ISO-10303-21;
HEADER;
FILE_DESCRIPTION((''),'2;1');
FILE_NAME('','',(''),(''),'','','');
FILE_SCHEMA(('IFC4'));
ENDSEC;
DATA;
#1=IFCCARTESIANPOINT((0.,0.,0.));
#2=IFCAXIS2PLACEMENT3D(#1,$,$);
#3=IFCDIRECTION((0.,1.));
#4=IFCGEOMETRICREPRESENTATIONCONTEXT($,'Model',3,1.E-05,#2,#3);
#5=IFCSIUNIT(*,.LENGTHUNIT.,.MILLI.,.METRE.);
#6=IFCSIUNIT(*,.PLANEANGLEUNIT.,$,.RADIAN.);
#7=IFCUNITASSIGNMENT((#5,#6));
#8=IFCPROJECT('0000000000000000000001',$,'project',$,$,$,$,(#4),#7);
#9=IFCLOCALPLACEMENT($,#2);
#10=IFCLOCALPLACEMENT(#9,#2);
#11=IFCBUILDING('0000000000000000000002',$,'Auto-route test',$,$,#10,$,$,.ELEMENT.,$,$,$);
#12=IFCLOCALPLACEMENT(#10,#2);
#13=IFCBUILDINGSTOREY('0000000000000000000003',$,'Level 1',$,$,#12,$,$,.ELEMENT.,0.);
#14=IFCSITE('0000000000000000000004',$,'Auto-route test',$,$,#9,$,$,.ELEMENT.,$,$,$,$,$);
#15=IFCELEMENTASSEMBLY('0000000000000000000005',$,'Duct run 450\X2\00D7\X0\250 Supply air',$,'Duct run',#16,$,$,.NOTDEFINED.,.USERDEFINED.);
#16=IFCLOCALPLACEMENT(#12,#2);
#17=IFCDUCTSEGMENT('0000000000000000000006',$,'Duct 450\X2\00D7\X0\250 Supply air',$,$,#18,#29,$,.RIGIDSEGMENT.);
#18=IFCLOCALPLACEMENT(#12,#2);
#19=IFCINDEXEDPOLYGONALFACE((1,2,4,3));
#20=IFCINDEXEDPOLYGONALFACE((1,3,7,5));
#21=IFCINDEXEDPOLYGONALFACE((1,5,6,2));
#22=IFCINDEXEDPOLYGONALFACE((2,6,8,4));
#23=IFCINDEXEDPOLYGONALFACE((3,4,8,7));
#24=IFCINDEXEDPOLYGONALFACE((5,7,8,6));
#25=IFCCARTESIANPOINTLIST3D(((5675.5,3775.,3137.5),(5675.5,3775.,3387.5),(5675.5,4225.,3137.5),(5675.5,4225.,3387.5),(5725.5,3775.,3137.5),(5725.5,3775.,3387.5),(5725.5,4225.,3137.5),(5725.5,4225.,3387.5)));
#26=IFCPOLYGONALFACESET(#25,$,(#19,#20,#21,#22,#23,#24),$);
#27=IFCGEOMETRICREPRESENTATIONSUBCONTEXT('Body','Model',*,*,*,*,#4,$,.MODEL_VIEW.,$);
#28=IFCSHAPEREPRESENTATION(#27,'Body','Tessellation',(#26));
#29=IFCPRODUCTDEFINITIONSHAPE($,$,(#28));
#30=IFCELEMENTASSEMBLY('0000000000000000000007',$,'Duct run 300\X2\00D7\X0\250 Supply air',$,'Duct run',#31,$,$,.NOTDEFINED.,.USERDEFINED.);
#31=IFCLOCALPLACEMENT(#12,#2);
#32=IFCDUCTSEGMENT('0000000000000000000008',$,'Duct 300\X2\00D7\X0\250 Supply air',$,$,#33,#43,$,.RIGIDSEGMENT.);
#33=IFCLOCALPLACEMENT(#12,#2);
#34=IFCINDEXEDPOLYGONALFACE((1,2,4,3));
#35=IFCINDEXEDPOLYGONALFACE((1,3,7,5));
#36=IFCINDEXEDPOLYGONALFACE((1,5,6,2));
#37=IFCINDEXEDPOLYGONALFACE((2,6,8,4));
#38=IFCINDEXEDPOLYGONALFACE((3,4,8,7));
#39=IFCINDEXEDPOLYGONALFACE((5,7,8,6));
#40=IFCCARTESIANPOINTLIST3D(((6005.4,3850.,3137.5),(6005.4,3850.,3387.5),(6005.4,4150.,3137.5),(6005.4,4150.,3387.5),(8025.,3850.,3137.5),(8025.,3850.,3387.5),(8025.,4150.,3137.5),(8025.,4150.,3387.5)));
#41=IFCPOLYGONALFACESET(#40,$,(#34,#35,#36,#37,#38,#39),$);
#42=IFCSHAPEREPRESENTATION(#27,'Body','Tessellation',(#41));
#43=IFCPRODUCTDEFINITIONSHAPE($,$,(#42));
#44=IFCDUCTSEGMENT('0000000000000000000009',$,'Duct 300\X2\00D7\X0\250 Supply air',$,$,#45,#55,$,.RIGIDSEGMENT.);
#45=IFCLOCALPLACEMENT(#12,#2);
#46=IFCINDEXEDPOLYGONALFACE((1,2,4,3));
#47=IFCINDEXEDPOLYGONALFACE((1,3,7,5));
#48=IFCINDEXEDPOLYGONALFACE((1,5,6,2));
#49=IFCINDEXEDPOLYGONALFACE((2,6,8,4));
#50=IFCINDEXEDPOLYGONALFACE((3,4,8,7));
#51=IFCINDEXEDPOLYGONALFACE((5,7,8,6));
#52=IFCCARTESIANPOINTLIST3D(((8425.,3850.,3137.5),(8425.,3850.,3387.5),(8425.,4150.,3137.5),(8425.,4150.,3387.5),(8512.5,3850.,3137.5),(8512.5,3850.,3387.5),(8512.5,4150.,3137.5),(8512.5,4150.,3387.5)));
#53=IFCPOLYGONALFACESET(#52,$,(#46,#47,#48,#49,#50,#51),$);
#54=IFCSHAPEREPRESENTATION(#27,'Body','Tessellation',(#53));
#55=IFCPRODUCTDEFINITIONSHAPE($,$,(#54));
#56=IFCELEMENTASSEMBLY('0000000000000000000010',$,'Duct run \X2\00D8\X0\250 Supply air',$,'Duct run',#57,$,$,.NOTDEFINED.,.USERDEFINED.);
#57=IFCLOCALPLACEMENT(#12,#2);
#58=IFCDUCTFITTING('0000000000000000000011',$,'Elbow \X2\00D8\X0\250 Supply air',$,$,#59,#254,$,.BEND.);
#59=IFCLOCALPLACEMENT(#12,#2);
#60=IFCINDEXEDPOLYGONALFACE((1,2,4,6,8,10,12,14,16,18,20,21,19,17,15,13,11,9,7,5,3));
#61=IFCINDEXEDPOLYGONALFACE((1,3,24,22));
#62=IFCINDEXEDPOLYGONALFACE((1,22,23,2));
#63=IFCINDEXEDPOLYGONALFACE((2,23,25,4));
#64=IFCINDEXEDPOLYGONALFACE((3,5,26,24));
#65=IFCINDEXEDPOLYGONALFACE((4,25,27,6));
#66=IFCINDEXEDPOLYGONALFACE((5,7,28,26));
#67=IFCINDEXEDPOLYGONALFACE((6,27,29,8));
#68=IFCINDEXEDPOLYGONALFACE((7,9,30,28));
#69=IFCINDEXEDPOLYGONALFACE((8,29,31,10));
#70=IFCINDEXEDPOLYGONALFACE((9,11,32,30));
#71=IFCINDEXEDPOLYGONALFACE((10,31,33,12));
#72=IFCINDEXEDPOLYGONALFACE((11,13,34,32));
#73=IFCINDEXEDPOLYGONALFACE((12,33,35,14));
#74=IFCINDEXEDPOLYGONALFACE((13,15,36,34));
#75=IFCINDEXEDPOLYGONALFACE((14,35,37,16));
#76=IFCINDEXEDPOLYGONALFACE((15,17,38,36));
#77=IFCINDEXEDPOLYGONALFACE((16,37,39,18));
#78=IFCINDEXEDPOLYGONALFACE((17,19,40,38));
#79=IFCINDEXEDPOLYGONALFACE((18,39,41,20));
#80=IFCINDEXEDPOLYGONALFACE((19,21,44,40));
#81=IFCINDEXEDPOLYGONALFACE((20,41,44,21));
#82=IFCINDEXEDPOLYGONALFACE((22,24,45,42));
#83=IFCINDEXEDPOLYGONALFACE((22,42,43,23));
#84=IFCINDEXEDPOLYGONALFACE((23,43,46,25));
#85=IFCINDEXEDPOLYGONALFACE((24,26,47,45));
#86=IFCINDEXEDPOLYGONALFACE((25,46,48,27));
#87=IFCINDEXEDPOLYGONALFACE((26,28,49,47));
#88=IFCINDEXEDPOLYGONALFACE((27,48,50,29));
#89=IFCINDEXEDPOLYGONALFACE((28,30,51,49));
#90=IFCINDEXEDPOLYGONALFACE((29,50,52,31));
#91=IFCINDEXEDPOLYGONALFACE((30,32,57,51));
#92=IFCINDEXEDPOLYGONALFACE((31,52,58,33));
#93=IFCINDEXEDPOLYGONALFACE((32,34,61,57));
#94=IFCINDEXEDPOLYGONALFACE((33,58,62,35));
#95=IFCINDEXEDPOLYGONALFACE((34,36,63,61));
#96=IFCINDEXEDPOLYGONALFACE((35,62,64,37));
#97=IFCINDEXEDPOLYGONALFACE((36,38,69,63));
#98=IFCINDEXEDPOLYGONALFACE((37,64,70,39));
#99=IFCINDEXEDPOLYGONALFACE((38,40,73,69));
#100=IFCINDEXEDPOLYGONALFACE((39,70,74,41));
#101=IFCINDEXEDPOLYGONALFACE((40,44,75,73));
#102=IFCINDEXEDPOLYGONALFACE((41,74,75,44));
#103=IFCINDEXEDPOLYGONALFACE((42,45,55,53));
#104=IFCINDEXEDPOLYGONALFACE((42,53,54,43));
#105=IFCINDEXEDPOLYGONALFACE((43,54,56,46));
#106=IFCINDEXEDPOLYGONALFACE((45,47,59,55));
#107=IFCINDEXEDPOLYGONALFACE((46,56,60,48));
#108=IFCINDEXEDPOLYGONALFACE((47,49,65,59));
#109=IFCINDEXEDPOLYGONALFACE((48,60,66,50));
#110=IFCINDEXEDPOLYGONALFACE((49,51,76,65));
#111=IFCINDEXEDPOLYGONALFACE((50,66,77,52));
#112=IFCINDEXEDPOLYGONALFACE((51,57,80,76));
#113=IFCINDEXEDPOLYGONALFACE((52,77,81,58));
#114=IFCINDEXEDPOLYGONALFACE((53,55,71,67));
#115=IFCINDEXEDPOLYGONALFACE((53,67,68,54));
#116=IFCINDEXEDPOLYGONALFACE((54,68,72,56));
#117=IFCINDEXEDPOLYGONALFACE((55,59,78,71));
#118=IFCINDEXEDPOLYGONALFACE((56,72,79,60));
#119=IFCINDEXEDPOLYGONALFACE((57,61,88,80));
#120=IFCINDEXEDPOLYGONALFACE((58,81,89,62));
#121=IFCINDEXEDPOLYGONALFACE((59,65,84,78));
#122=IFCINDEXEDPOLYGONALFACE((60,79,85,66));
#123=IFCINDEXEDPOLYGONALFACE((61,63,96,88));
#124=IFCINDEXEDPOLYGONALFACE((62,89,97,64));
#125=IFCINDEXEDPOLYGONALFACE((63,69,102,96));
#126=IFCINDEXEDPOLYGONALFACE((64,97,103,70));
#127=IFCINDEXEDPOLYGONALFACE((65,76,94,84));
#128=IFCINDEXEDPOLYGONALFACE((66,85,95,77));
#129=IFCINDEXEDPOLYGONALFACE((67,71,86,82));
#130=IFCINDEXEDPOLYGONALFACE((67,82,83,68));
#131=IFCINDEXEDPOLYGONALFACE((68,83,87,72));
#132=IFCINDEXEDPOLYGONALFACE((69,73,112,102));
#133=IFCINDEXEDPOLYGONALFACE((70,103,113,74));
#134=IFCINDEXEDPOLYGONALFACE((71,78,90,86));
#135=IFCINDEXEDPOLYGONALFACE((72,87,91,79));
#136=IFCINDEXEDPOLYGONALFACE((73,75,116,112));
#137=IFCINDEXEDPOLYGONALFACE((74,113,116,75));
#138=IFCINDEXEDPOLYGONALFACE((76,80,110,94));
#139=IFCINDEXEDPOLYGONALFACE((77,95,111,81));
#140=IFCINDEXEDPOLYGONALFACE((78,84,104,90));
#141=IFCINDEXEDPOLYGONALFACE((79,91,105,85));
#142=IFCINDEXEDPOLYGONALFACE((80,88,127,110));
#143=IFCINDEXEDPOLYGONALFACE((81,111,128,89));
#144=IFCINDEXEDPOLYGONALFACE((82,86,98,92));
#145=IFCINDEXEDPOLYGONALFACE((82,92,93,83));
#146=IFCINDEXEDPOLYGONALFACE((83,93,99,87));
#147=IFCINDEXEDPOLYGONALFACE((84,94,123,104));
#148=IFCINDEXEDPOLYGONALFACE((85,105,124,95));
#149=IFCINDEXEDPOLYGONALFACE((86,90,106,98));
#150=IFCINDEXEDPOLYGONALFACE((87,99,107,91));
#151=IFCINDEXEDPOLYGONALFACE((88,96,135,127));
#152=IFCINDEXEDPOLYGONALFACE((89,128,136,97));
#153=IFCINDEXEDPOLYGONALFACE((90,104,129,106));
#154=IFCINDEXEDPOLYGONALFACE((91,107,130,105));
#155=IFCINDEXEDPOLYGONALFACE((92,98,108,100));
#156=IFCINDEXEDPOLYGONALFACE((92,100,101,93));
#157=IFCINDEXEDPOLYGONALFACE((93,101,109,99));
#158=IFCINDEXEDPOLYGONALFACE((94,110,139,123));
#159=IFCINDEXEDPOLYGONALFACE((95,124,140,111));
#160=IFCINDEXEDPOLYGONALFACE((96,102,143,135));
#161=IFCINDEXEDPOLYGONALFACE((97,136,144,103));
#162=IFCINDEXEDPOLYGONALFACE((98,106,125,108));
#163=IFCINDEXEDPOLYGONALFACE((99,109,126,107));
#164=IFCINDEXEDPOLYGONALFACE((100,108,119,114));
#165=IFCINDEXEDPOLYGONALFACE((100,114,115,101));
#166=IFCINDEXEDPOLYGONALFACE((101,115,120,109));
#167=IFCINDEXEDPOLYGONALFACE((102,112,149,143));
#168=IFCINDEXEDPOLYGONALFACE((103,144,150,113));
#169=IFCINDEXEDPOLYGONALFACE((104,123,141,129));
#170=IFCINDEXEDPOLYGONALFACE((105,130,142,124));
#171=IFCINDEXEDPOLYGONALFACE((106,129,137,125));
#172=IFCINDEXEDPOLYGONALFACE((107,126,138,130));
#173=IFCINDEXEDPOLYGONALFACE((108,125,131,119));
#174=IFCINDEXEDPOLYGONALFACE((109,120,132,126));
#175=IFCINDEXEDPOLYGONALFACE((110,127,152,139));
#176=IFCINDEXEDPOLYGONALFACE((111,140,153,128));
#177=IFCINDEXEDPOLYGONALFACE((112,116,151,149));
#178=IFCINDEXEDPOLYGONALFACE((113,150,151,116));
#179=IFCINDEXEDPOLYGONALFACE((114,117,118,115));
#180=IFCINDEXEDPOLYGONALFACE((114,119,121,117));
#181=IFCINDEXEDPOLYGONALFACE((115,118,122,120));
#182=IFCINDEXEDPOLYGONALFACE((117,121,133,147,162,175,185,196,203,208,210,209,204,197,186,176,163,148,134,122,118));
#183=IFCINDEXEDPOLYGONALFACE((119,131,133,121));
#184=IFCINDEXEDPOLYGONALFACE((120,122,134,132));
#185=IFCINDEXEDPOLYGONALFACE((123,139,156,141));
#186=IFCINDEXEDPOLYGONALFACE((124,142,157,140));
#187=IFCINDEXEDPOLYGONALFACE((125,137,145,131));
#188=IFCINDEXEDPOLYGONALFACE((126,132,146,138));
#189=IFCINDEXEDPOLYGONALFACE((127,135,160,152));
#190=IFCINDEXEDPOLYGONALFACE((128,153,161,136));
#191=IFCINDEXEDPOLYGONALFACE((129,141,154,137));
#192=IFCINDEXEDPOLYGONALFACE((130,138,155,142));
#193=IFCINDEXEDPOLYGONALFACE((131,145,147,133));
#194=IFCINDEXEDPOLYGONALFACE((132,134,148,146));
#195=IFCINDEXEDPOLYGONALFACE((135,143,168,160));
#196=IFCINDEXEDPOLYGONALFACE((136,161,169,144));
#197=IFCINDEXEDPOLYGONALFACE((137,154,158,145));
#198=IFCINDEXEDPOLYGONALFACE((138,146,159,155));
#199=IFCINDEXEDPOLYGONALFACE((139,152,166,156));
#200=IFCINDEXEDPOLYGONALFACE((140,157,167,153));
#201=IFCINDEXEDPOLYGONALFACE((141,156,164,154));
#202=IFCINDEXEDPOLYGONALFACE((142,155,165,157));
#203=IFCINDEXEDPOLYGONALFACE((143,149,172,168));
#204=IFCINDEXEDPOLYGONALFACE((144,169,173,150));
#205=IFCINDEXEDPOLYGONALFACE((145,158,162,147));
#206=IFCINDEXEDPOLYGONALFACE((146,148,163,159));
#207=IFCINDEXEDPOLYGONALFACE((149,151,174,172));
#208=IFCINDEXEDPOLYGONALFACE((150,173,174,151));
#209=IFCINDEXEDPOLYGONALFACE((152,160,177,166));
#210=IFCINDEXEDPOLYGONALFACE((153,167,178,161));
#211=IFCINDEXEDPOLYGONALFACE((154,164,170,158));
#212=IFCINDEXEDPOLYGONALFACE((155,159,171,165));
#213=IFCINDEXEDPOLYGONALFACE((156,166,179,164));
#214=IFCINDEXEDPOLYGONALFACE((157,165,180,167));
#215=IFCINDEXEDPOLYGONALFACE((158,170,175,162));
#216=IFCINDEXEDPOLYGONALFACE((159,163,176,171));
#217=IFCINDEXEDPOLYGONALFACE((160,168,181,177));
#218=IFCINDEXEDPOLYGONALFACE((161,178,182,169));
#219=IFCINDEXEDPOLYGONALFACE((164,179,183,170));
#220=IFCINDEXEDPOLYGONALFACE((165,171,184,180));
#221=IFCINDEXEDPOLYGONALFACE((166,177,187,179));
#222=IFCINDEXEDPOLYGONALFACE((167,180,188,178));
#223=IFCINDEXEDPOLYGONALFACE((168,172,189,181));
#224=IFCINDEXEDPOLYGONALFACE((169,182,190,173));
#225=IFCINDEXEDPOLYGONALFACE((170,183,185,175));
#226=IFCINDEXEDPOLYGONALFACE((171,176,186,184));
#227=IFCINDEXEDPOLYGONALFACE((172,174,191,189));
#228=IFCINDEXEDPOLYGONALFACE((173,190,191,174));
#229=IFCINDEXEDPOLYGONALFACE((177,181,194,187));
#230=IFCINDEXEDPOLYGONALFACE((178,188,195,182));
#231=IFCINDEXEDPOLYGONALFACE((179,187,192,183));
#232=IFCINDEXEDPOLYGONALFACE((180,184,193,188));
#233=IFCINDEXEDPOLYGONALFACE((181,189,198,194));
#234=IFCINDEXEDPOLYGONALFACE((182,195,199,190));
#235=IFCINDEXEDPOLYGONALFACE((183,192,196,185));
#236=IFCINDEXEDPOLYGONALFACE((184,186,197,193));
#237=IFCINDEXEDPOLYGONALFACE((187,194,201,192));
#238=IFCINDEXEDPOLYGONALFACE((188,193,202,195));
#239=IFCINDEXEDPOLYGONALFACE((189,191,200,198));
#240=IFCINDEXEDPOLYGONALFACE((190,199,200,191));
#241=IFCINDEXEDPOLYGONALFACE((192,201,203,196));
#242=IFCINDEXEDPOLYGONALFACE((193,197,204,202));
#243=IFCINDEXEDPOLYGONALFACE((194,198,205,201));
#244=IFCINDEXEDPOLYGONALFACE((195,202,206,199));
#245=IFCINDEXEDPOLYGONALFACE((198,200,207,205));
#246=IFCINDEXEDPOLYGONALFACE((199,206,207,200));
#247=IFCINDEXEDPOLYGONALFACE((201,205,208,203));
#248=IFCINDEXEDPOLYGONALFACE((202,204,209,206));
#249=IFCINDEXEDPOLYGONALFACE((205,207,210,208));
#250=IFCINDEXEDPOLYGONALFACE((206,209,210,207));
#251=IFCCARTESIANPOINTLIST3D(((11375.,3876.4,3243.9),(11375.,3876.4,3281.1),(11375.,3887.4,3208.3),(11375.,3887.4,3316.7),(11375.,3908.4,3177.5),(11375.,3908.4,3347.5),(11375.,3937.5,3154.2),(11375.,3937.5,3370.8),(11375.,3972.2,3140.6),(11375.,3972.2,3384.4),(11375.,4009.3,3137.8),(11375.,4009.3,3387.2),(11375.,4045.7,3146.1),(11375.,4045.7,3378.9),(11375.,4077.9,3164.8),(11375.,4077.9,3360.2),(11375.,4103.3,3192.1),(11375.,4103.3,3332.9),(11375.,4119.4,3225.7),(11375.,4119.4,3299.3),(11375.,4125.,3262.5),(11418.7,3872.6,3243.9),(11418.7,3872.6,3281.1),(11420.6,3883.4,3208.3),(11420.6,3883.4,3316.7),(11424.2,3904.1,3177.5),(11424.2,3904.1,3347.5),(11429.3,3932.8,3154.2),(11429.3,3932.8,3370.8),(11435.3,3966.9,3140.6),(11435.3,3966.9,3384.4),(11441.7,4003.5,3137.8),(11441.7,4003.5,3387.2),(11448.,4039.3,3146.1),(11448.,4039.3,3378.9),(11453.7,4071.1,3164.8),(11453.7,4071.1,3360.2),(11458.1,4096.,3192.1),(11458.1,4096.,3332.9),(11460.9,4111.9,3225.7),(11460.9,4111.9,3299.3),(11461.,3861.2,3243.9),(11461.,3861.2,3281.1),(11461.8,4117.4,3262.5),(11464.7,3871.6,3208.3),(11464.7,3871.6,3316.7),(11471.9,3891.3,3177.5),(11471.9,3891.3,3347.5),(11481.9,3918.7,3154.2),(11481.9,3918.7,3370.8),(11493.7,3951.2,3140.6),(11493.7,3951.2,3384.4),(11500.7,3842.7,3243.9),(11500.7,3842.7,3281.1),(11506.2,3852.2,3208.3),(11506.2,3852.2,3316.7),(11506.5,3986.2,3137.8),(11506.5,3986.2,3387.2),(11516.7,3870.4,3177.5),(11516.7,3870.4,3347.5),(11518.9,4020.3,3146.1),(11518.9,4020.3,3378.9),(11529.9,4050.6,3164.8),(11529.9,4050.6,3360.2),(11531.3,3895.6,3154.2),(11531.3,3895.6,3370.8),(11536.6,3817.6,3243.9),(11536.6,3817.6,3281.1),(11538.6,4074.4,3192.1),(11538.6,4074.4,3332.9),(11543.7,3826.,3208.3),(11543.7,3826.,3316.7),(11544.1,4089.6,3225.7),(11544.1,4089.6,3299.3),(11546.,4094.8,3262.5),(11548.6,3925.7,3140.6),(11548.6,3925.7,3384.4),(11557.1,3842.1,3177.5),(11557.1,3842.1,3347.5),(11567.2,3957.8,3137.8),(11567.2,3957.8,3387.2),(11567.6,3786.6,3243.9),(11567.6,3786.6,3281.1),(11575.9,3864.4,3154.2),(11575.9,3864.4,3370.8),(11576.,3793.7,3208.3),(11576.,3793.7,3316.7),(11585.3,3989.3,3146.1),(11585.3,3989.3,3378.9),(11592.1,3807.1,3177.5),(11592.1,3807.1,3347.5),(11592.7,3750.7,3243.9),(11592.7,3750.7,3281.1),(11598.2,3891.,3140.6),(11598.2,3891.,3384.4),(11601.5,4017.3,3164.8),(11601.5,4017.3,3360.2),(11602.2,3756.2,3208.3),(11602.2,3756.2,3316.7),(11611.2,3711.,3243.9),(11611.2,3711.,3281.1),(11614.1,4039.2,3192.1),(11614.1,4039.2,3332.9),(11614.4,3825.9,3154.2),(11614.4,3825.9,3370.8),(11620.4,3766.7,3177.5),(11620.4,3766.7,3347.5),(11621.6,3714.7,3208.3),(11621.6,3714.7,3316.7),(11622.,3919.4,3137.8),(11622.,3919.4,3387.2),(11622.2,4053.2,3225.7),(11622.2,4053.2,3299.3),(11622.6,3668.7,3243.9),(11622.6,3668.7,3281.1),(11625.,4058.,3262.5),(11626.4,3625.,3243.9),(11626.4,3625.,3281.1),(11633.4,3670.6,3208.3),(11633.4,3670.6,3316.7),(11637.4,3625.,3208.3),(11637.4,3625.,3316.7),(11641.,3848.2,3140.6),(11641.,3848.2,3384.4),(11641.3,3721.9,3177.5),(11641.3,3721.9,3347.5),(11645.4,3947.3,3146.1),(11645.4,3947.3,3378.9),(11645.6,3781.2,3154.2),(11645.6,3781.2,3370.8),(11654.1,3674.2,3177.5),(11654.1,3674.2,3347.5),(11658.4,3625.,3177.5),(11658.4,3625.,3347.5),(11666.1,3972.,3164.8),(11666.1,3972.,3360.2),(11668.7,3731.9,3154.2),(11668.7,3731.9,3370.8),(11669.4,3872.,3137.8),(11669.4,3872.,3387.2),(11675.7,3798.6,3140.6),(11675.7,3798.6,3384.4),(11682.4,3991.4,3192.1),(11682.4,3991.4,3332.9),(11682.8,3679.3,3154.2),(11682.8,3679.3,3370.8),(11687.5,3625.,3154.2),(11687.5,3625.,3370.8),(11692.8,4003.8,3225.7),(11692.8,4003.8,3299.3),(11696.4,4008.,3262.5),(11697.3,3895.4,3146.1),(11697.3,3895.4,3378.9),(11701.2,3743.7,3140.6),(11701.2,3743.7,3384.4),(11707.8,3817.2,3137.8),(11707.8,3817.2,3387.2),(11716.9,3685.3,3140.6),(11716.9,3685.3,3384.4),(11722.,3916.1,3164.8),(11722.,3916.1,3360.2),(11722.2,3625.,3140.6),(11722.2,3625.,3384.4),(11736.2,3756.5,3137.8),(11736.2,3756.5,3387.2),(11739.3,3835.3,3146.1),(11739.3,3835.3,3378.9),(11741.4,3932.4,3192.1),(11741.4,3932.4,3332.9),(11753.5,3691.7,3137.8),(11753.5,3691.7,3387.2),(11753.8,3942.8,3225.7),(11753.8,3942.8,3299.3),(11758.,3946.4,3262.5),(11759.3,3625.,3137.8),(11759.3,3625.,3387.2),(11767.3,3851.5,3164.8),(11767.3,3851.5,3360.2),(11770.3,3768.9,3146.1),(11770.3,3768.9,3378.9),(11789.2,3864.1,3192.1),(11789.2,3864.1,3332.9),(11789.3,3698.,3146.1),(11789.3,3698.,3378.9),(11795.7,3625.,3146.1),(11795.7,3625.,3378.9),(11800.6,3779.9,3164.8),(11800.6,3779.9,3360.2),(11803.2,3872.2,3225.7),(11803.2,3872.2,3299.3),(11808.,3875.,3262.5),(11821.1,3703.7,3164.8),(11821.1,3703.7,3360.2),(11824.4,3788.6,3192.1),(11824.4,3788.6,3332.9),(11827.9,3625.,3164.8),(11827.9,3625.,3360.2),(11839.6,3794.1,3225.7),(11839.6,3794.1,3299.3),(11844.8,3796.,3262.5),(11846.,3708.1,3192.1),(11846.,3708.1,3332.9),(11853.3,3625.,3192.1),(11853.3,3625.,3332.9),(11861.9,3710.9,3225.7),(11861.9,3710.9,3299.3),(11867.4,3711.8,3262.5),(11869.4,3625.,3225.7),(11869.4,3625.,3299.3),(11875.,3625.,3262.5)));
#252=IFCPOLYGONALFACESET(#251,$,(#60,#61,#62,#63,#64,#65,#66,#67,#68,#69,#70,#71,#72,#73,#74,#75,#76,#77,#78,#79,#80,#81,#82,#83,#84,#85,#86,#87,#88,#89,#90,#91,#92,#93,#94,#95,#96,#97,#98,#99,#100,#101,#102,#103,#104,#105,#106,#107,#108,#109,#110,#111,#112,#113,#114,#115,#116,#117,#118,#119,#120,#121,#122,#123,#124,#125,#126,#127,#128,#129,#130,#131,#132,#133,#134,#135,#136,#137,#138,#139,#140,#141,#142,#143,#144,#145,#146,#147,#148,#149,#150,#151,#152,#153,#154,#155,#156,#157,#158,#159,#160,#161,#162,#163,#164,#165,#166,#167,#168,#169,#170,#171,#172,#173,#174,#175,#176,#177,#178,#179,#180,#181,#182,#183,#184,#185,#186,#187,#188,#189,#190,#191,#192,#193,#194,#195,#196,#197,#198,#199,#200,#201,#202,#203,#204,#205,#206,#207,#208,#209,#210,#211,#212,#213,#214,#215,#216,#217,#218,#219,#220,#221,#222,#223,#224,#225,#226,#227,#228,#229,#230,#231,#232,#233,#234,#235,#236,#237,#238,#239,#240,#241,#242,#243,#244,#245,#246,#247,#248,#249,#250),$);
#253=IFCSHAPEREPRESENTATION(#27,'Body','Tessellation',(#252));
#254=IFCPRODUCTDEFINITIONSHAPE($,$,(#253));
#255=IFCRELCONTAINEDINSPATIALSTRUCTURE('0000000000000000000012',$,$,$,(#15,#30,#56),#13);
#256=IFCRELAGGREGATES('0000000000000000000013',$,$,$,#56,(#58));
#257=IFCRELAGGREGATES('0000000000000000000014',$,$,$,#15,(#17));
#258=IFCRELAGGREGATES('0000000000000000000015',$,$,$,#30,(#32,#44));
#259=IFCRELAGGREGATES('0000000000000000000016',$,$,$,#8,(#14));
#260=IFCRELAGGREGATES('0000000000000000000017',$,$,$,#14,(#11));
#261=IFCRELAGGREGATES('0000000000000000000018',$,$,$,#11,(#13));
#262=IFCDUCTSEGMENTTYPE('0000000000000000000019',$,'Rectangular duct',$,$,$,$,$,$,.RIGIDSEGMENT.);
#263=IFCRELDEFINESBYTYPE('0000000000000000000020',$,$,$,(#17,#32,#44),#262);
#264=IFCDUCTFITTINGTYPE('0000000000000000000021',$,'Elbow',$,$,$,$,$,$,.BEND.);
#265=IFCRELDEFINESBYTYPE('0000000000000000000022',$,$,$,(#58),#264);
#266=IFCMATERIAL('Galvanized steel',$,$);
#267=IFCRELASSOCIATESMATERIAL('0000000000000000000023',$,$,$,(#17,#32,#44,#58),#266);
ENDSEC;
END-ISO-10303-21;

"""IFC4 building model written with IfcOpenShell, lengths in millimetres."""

from ifc_helpers import new_model, entity, si_unit, direction, frame, origin, origin_with_axes, origin_2d, place, context, subcontext, project, spatial, rectangle, extrude, material, type_object, element, aggregate, save


model = new_model("IFC4")

# Units and contexts
model_context = context("Model", 3, precision=1e-05, world=origin(), true_north=direction((0.0, 1.0)))
body_context = subcontext(model_context, "Body", "Model", "MODEL_VIEW")
ifc_project = project(units=[si_unit("LENGTHUNIT", "METRE", prefix="MILLI"), si_unit("PLANEANGLEUNIT", "RADIAN")], contexts=[model_context])

# Site, building, storey
site_placement = place(None, origin())
site = spatial("IfcSite", under=ifc_project, at=site_placement, Name="Auto-route test", CompositionType="ELEMENT")
building_placement = place(site_placement, origin())
building = spatial("IfcBuilding", under=site, at=building_placement, Name="Auto-route test", CompositionType="ELEMENT")
storey_placement = place(building_placement, origin())
storey = spatial("IfcBuildingStorey", under=building, at=storey_placement, Name="Level 1", CompositionType="ELEMENT", Elevation=0.0)

# Element assemblies, duct segments
assembly_1_placement = place(storey_placement, origin_with_axes())
assembly_1 = element("IfcElementAssembly", 1, at=assembly_1_placement, inside=storey, Name="Duct run 450×250 Supply air", ObjectType="Duct run", AssemblyPlace="NOTDEFINED", PredefinedType="USERDEFINED")
ifc_material_1 = material(Name="Galvanized steel")
duct_segment_type_1 = type_object("IfcDuctSegmentType", Name="Rectangular duct", PredefinedType="RIGIDSEGMENT")
duct_segment_1_placement = place(storey_placement, origin_with_axes())
duct_segment_1 = element("IfcDuctSegment", 2, at=duct_segment_1_placement, type_object=duct_segment_type_1, material=ifc_material_1, Name="Duct 450×250 Supply air", PredefinedType="RIGIDSEGMENT", context=body_context, shape_type="SweptSolid", body=[
    extrude(rectangle(XDim=450.0, YDim=250.0, at=origin_2d()), frame((5675.5, 4000.0, 3262.5), z_axis=(1.0, 0.0, 0.0), x_axis=(0.0, 1.0, 0.0)), (0.0, 0.0, 1.0), 50.0),
])
assembly_2_placement = place(storey_placement, origin_with_axes())
assembly_2 = element("IfcElementAssembly", 3, at=assembly_2_placement, inside=storey, Name="Duct run 300×250 Supply air", ObjectType="Duct run", AssemblyPlace="NOTDEFINED", PredefinedType="USERDEFINED")
duct_segment_2_placement = place(storey_placement, origin_with_axes())
duct_segment_2 = element("IfcDuctSegment", 4, at=duct_segment_2_placement, type_object=duct_segment_type_1, material=ifc_material_1, Name="Duct 300×250 Supply air", PredefinedType="RIGIDSEGMENT", context=body_context, shape_type="SweptSolid", body=[
    extrude(rectangle(XDim=300.0, YDim=250.0, at=origin_2d()), frame((6005.4, 4000.0, 3262.5), z_axis=(1.0, 0.0, 0.0), x_axis=(0.0, 1.0, 0.0)), (0.0, 0.0, 1.0), 2019.6),
])
duct_segment_3_placement = place(storey_placement, origin_with_axes())
duct_segment_3 = element("IfcDuctSegment", 5, at=duct_segment_3_placement, type_object=duct_segment_type_1, material=ifc_material_1, Name="Duct 300×250 Supply air", PredefinedType="RIGIDSEGMENT", context=body_context, shape_type="SweptSolid", body=[
    extrude(rectangle(XDim=300.0, YDim=250.0, at=origin_2d()), frame((8425.0, 4000.0, 3262.5), z_axis=(1.0, 0.0, 0.0), x_axis=(0.0, 1.0, 0.0)), (0.0, 0.0, 1.0), 87.5),
])

# Element assembly, duct fitting
assembly_3_placement = place(storey_placement, origin_with_axes())
assembly_3 = element("IfcElementAssembly", 6, at=assembly_3_placement, inside=storey, Name="Duct run Ø250 Supply air", ObjectType="Duct run", AssemblyPlace="NOTDEFINED", PredefinedType="USERDEFINED")
duct_fitting_type_1 = type_object("IfcDuctFittingType", Name="Elbow", PredefinedType="BEND")
duct_fitting_1_placement = place(storey_placement, origin_with_axes())
duct_fitting_1 = element("IfcDuctFitting", 7, at=duct_fitting_1_placement, type_object=duct_fitting_type_1, material=ifc_material_1, Name="Elbow Ø250 Supply air", PredefinedType="BEND", context=body_context, shape_type="SweptSolid", body=[
    entity("IfcRevolvedAreaSolid", entity("IfcCircleProfileDef", "AREA", None, entity("IfcAxis2Placement2D", entity("IfcCartesianPoint", [0.0, 0.0])), 125.0), entity("IfcAxis2Placement3D", entity("IfcCartesianPoint", [11375.0, 4000.0, 3262.5]), entity("IfcDirection", [1.0, 0.0, 0.0]), entity("IfcDirection", [0.0, 1.0, 0.0])), entity("IfcAxis1Placement", entity("IfcCartesianPoint", [-375.0, 0.0, 0.0]), entity("IfcDirection", [0.0, -1.0, 0.0])), 1.570796),
])

aggregate(assembly_3, [duct_fitting_1])

aggregate(assembly_1, [duct_segment_1])
aggregate(assembly_2, [duct_segment_2, duct_segment_3])

save(model, "model.ifc")
